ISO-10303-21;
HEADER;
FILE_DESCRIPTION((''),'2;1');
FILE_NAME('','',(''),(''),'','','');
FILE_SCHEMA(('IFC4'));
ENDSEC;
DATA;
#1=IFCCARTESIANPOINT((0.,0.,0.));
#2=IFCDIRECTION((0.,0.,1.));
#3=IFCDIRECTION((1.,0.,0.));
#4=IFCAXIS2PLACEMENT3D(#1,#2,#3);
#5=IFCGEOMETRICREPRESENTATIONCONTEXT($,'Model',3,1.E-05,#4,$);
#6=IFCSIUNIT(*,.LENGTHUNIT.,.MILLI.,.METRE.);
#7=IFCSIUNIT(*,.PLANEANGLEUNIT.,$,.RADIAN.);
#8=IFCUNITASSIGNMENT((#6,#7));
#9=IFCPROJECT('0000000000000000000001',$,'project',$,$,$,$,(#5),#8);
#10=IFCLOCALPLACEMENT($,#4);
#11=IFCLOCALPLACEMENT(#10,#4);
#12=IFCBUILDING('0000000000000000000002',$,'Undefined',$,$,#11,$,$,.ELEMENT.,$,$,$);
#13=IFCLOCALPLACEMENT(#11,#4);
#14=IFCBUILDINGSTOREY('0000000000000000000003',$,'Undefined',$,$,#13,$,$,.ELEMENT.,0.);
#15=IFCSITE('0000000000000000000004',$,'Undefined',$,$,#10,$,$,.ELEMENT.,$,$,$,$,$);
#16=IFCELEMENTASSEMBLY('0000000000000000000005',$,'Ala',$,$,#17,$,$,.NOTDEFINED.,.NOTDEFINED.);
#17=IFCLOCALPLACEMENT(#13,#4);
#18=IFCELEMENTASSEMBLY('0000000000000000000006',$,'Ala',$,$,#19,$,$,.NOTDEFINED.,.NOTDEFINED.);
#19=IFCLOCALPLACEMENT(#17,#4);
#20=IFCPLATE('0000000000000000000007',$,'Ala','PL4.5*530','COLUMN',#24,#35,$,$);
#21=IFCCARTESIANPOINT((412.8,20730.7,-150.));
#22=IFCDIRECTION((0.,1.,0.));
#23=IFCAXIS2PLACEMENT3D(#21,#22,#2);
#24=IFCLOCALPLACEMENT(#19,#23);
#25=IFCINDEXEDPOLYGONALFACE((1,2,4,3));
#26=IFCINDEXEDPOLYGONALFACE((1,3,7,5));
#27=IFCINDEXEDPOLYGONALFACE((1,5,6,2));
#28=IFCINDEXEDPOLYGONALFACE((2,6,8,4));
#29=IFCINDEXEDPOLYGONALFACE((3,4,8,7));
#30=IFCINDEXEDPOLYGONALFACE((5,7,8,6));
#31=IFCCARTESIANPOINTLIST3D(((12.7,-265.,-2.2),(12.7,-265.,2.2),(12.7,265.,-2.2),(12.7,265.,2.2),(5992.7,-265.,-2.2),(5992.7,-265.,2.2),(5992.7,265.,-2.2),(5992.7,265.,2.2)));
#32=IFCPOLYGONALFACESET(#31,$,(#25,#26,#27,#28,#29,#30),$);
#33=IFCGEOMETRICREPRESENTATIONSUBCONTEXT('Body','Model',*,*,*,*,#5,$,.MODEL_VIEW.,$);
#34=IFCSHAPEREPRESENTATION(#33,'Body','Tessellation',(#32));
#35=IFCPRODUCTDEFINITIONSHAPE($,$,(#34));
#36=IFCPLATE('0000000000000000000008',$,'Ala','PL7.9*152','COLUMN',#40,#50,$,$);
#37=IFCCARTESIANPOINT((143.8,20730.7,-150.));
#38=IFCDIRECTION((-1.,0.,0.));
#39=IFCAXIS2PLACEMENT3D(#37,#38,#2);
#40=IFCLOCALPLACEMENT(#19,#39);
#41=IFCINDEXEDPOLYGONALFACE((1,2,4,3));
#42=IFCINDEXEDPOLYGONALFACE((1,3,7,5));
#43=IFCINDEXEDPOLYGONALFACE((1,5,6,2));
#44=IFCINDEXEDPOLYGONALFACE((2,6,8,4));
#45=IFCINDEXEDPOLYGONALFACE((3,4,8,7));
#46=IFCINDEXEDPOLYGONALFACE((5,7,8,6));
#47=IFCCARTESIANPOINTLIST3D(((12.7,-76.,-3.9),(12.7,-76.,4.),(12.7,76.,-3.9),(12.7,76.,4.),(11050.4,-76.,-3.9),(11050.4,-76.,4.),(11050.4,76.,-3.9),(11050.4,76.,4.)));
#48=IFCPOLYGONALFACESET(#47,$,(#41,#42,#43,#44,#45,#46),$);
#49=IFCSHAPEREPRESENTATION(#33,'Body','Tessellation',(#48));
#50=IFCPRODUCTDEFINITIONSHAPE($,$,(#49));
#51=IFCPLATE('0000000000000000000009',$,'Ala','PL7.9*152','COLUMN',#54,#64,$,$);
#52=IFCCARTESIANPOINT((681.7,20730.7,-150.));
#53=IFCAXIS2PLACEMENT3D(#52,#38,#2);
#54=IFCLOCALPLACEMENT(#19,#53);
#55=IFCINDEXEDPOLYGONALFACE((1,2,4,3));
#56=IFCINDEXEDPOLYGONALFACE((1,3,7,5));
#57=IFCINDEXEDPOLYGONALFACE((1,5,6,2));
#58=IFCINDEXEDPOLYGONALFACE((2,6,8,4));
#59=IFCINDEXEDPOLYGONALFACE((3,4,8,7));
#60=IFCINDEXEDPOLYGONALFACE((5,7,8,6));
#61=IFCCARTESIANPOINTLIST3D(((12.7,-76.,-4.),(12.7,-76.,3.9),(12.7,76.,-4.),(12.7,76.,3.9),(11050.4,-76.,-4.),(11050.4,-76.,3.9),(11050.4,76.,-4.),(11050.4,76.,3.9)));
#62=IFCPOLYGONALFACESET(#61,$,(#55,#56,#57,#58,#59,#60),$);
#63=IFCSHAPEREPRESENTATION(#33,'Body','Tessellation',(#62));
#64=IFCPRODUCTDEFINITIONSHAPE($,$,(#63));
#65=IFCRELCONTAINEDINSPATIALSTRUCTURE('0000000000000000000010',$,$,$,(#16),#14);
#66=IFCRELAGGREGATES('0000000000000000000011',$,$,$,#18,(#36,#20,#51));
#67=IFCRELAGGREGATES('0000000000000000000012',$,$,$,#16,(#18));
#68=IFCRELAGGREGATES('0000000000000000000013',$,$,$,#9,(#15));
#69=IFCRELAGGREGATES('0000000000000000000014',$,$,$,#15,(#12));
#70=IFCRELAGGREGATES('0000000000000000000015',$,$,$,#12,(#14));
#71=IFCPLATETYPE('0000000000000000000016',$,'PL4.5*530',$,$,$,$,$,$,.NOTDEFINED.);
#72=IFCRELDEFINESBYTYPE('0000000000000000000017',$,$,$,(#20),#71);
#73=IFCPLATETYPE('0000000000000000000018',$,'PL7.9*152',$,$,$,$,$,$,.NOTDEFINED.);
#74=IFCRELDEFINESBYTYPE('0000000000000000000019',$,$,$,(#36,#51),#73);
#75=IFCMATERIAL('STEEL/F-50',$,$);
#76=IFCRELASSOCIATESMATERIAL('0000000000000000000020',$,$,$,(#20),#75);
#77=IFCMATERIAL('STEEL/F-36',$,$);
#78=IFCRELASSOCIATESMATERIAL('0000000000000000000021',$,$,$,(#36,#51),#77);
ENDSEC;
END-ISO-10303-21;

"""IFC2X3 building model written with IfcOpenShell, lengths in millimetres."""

from ifc_helpers import new_model, si_unit, frame, origin_with_axes, place, context, subcontext, project, spatial, polyline, outline, extrude, clip, halfspace, material, type_object, element, aggregate, save


model = new_model("IFC2X3")

# Units and contexts
model_context = context("Model", 3, precision=1e-05, world=origin_with_axes())
body_context = subcontext(model_context, "Body", "Model", "MODEL_VIEW")
ifc_project = project(units=[si_unit("LENGTHUNIT", "METRE", prefix="MILLI"), si_unit("PLANEANGLEUNIT", "RADIAN")], contexts=[model_context])

# Site, building, storey
site_placement = place(None, origin_with_axes())
site = spatial("IfcSite", under=ifc_project, at=site_placement, Name="Undefined", CompositionType="ELEMENT")
building_placement = place(site_placement, origin_with_axes())
building = spatial("IfcBuilding", under=site, at=building_placement, Name="Undefined", CompositionType="ELEMENT")
storey_placement = place(building_placement, origin_with_axes())
storey = spatial("IfcBuildingStorey", under=building, at=storey_placement, Name="Undefined", CompositionType="ELEMENT", Elevation=0.0)

# Element assembly
assembly_1_placement = place(storey_placement, origin_with_axes())
assembly_1 = element("IfcElementAssembly", 1, at=assembly_1_placement, inside=storey, Name="Ala", AssemblyPlace="NOTDEFINED", PredefinedType="NOTDEFINED")
ifc_material_1 = material(Name="STEEL/F-50")

# Element assembly, plates
assembly_2_placement = place(assembly_1_placement, origin_with_axes())
assembly_2 = element("IfcElementAssembly", 2, at=assembly_2_placement, Name="Ala", AssemblyPlace="NOTDEFINED", PredefinedType="NOTDEFINED")
plate_type_1 = type_object("IfcPlateType", Name="PL4.5*530", PredefinedType="NOTDEFINED")
plate_1_placement = place(assembly_2_placement, frame((412.8, 20730.7, -150.0), z_axis=(0.0, 1.0, 0.0), x_axis=(0.0, 0.0, 1.0)))
plate_1 = element("IfcPlate", 3, at=plate_1_placement, type_object=plate_type_1, material=ifc_material_1, Name="Ala", Description="PL4.5*530", ObjectType="COLUMN", context=body_context, shape_type="Clipping", body=[
    clip(extrude(outline(polyline([(12.7, -265.0), (12.7, 265.0), (5992.7, 265.0), (5992.7, -265.0), (12.7, -265.0)])), frame((0.0, 0.0, -2.2), z_axis=(0.0, 0.0, 1.0), x_axis=(1.0, 0.0, 0.0)), (0.0, 0.0, 1.0), 4.5), halfspace(frame((12.7, 0.0, 0.0), z_axis=(1.0, 0.0, 0.0), x_axis=(0.0, 0.0, 1.0)), True)),
])
ifc_material_2 = material(Name="STEEL/F-36")
plate_type_2 = type_object("IfcPlateType", Name="PL7.9*152", PredefinedType="NOTDEFINED")
plate_2_placement = place(assembly_2_placement, frame((143.8, 20730.7, -150.0), z_axis=(-1.0, 0.0, 0.0), x_axis=(0.0, 0.0, 1.0)))
plate_2 = element("IfcPlate", 4, at=plate_2_placement, type_object=plate_type_2, material=ifc_material_2, Name="Ala", Description="PL7.9*152", ObjectType="COLUMN", context=body_context, shape_type="Clipping", body=[
    clip(extrude(outline(polyline([(12.7, -76.0), (12.7, 76.0), (11050.4, 76.0), (11050.4, -76.0), (12.7, -76.0)])), frame((0.0, 0.0, -4.0), z_axis=(0.0, 0.0, 1.0), x_axis=(1.0, 0.0, 0.0)), (0.0, 0.0, 1.0), 7.9), halfspace(frame((12.7, 0.0, 0.0), z_axis=(1.0, 0.0, 0.0), x_axis=(0.0, -1.0, 0.0)), True)),
])
plate_3_placement = place(assembly_2_placement, frame((681.7, 20730.7, -150.0), z_axis=(-1.0, 0.0, 0.0), x_axis=(0.0, 0.0, 1.0)))
plate_3 = element("IfcPlate", 5, at=plate_3_placement, type_object=plate_type_2, material=ifc_material_2, Name="Ala", Description="PL7.9*152", ObjectType="COLUMN", context=body_context, shape_type="Clipping", body=[
    clip(extrude(outline(polyline([(12.7, -76.0), (12.7, 76.0), (11050.4, 76.0), (11050.4, -76.0), (12.7, -76.0)])), frame((0.0, 0.0, -4.0), z_axis=(0.0, 0.0, 1.0), x_axis=(1.0, 0.0, 0.0)), (0.0, 0.0, 1.0), 7.9), halfspace(frame((12.7, 0.0, 0.0), z_axis=(1.0, 0.0, 0.0), x_axis=(0.0, 1.0, 0.0)), True)),
])
aggregate(assembly_2, [plate_2, plate_1, plate_3])

aggregate(assembly_1, [assembly_2])

save(model, "model.ifc")
